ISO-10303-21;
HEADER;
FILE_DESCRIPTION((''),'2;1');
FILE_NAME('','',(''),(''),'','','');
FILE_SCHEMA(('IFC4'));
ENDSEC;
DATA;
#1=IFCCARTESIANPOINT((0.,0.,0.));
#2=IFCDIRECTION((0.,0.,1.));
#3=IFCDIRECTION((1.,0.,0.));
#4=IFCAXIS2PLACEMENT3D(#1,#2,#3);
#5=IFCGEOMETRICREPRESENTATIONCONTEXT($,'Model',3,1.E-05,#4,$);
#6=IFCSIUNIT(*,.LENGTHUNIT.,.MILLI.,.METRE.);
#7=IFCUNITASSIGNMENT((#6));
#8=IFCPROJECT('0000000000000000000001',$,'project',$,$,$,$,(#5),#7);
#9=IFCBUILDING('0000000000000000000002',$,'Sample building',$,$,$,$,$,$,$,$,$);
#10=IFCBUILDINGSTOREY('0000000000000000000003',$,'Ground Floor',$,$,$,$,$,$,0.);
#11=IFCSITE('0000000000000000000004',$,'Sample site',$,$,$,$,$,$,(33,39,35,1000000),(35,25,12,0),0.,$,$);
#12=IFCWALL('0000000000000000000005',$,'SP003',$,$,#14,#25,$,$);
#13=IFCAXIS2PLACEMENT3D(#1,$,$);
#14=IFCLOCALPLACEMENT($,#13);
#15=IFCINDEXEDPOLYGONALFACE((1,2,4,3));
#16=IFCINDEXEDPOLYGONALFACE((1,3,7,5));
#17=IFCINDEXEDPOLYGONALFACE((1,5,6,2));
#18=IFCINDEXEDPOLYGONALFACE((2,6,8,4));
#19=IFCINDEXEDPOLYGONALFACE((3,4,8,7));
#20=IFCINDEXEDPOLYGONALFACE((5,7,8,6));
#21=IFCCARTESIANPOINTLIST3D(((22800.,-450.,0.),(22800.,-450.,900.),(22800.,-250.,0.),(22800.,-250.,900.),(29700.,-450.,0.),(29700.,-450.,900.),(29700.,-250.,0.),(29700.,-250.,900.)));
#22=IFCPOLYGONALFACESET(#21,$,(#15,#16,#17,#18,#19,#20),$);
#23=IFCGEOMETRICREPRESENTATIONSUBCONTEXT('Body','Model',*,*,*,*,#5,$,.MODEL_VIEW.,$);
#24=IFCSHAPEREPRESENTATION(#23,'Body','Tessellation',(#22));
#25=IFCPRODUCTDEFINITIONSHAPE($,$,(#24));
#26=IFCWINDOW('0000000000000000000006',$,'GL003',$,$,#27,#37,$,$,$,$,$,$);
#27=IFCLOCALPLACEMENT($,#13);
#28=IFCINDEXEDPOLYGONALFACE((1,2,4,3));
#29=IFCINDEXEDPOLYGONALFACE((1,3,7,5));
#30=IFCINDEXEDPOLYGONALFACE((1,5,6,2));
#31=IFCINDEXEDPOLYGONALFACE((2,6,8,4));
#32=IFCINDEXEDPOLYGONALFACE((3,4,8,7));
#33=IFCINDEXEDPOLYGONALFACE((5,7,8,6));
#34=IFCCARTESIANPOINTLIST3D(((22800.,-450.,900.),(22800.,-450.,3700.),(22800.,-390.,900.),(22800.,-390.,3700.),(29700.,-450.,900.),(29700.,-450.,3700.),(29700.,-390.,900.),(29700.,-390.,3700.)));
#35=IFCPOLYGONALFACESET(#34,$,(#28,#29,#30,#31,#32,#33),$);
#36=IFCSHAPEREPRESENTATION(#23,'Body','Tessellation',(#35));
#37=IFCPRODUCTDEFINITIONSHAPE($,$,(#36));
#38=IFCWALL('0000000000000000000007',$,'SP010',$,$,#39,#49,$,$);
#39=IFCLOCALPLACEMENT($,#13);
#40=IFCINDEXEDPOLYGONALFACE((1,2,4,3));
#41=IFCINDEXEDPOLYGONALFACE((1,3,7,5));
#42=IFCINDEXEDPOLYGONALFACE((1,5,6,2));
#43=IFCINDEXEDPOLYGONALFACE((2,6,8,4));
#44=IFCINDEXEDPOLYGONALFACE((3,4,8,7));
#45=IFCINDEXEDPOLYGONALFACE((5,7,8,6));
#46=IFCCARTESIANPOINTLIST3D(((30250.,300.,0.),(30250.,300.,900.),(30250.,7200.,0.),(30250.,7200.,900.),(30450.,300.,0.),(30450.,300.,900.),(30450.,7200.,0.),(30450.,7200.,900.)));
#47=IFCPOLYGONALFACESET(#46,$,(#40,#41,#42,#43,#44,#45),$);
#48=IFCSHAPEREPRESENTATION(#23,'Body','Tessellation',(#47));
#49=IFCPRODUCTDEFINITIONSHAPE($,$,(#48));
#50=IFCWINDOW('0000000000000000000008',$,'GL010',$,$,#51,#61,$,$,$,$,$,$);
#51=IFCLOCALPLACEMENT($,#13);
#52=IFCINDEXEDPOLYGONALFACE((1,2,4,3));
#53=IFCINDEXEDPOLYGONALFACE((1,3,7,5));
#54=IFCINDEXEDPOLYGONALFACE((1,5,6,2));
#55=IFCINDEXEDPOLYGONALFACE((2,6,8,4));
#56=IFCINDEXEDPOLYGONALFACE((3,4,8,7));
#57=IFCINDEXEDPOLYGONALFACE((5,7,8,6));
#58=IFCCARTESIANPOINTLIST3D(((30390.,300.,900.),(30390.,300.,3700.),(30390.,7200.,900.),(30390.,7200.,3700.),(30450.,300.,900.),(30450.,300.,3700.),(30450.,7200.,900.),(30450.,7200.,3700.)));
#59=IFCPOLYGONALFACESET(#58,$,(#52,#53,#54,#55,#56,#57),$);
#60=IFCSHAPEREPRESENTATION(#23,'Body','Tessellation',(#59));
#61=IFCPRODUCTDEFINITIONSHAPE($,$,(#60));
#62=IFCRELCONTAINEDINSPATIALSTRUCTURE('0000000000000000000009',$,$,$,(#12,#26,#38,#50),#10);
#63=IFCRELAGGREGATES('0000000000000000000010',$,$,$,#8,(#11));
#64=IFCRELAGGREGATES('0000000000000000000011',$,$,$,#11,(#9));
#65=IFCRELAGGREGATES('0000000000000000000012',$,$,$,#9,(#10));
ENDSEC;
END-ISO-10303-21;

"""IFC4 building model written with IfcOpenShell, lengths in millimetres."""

from ifc_helpers import new_model, si_unit, frame, origin_with_axes, place, context, subcontext, project, spatial, indexed_curve, outline, extrude, element, save


model = new_model("IFC4")

# Units and contexts
model_context = context("Model", 3, precision=1e-05, world=origin_with_axes())
body_context = subcontext(model_context, "Body", "Model", "MODEL_VIEW")
ifc_project = project(units=[si_unit("LENGTHUNIT", "METRE", prefix="MILLI")], contexts=[model_context])

# Site, building, storey
site = spatial("IfcSite", under=ifc_project, Name="Sample site", RefLatitude=(33, 39, 35, 1000000), RefLongitude=(35, 25, 12, 0), RefElevation=0.0)
building = spatial("IfcBuilding", under=site, Name="Sample building")
storey = spatial("IfcBuildingStorey", under=building, Name="Ground Floor", Elevation=0.0)

# Wall
wall_1_placement = place(None, frame((22800.0, -450.0, 0.0), z_axis=(0.0, 0.0, 1.0), x_axis=(1.0, 0.0, 0.0)))
element("IfcWall", 1, at=wall_1_placement, inside=storey, Name="SP003", context=body_context, shape_type="SweptSolid", body=[
    extrude(outline(indexed_curve([(0.0, 0.0), (0.0, 200.0), (6900.0, 200.0), (6900.0, 0.0), (0.0, 0.0)], self_intersect=False)), origin_with_axes(), (0.0, 0.0, 1.0), 900.0),
])

# Window
window_1_placement = place(None, frame((22800.0, -450.0, 900.0), z_axis=(0.0, 0.0, 1.0), x_axis=(1.0, 0.0, 0.0)))
element("IfcWindow", 2, at=window_1_placement, inside=storey, Name="GL003", context=body_context, shape_type="SweptSolid", body=[
    extrude(outline(indexed_curve([(0.0, 0.0), (0.0, 60.0), (6900.0, 60.0), (6900.0, 0.0), (0.0, 0.0)], self_intersect=False)), origin_with_axes(), (0.0, 0.0, 1.0), 2800.0),
])

# Wall
wall_2_placement = place(None, frame((30450.0, 300.0, 0.0), z_axis=(0.0, 0.0, 1.0), x_axis=(0.0, 1.0, 0.0)))
element("IfcWall", 3, at=wall_2_placement, inside=storey, Name="SP010", context=body_context, shape_type="SweptSolid", body=[
    extrude(outline(indexed_curve([(0.0, 0.0), (0.0, 200.0), (6900.0, 200.0), (6900.0, 0.0), (0.0, 0.0)], self_intersect=False)), origin_with_axes(), (0.0, 0.0, 1.0), 900.0),
])

# Window
window_2_placement = place(None, frame((30450.0, 300.0, 900.0), z_axis=(0.0, 0.0, 1.0), x_axis=(0.0, 1.0, 0.0)))
element("IfcWindow", 4, at=window_2_placement, inside=storey, Name="GL010", context=body_context, shape_type="SweptSolid", body=[
    extrude(outline(indexed_curve([(0.0, 0.0), (0.0, 60.0), (6900.0, 60.0), (6900.0, 0.0), (0.0, 0.0)], self_intersect=False)), origin_with_axes(), (0.0, 0.0, 1.0), 2800.0),
])

save(model, "model.ifc")
